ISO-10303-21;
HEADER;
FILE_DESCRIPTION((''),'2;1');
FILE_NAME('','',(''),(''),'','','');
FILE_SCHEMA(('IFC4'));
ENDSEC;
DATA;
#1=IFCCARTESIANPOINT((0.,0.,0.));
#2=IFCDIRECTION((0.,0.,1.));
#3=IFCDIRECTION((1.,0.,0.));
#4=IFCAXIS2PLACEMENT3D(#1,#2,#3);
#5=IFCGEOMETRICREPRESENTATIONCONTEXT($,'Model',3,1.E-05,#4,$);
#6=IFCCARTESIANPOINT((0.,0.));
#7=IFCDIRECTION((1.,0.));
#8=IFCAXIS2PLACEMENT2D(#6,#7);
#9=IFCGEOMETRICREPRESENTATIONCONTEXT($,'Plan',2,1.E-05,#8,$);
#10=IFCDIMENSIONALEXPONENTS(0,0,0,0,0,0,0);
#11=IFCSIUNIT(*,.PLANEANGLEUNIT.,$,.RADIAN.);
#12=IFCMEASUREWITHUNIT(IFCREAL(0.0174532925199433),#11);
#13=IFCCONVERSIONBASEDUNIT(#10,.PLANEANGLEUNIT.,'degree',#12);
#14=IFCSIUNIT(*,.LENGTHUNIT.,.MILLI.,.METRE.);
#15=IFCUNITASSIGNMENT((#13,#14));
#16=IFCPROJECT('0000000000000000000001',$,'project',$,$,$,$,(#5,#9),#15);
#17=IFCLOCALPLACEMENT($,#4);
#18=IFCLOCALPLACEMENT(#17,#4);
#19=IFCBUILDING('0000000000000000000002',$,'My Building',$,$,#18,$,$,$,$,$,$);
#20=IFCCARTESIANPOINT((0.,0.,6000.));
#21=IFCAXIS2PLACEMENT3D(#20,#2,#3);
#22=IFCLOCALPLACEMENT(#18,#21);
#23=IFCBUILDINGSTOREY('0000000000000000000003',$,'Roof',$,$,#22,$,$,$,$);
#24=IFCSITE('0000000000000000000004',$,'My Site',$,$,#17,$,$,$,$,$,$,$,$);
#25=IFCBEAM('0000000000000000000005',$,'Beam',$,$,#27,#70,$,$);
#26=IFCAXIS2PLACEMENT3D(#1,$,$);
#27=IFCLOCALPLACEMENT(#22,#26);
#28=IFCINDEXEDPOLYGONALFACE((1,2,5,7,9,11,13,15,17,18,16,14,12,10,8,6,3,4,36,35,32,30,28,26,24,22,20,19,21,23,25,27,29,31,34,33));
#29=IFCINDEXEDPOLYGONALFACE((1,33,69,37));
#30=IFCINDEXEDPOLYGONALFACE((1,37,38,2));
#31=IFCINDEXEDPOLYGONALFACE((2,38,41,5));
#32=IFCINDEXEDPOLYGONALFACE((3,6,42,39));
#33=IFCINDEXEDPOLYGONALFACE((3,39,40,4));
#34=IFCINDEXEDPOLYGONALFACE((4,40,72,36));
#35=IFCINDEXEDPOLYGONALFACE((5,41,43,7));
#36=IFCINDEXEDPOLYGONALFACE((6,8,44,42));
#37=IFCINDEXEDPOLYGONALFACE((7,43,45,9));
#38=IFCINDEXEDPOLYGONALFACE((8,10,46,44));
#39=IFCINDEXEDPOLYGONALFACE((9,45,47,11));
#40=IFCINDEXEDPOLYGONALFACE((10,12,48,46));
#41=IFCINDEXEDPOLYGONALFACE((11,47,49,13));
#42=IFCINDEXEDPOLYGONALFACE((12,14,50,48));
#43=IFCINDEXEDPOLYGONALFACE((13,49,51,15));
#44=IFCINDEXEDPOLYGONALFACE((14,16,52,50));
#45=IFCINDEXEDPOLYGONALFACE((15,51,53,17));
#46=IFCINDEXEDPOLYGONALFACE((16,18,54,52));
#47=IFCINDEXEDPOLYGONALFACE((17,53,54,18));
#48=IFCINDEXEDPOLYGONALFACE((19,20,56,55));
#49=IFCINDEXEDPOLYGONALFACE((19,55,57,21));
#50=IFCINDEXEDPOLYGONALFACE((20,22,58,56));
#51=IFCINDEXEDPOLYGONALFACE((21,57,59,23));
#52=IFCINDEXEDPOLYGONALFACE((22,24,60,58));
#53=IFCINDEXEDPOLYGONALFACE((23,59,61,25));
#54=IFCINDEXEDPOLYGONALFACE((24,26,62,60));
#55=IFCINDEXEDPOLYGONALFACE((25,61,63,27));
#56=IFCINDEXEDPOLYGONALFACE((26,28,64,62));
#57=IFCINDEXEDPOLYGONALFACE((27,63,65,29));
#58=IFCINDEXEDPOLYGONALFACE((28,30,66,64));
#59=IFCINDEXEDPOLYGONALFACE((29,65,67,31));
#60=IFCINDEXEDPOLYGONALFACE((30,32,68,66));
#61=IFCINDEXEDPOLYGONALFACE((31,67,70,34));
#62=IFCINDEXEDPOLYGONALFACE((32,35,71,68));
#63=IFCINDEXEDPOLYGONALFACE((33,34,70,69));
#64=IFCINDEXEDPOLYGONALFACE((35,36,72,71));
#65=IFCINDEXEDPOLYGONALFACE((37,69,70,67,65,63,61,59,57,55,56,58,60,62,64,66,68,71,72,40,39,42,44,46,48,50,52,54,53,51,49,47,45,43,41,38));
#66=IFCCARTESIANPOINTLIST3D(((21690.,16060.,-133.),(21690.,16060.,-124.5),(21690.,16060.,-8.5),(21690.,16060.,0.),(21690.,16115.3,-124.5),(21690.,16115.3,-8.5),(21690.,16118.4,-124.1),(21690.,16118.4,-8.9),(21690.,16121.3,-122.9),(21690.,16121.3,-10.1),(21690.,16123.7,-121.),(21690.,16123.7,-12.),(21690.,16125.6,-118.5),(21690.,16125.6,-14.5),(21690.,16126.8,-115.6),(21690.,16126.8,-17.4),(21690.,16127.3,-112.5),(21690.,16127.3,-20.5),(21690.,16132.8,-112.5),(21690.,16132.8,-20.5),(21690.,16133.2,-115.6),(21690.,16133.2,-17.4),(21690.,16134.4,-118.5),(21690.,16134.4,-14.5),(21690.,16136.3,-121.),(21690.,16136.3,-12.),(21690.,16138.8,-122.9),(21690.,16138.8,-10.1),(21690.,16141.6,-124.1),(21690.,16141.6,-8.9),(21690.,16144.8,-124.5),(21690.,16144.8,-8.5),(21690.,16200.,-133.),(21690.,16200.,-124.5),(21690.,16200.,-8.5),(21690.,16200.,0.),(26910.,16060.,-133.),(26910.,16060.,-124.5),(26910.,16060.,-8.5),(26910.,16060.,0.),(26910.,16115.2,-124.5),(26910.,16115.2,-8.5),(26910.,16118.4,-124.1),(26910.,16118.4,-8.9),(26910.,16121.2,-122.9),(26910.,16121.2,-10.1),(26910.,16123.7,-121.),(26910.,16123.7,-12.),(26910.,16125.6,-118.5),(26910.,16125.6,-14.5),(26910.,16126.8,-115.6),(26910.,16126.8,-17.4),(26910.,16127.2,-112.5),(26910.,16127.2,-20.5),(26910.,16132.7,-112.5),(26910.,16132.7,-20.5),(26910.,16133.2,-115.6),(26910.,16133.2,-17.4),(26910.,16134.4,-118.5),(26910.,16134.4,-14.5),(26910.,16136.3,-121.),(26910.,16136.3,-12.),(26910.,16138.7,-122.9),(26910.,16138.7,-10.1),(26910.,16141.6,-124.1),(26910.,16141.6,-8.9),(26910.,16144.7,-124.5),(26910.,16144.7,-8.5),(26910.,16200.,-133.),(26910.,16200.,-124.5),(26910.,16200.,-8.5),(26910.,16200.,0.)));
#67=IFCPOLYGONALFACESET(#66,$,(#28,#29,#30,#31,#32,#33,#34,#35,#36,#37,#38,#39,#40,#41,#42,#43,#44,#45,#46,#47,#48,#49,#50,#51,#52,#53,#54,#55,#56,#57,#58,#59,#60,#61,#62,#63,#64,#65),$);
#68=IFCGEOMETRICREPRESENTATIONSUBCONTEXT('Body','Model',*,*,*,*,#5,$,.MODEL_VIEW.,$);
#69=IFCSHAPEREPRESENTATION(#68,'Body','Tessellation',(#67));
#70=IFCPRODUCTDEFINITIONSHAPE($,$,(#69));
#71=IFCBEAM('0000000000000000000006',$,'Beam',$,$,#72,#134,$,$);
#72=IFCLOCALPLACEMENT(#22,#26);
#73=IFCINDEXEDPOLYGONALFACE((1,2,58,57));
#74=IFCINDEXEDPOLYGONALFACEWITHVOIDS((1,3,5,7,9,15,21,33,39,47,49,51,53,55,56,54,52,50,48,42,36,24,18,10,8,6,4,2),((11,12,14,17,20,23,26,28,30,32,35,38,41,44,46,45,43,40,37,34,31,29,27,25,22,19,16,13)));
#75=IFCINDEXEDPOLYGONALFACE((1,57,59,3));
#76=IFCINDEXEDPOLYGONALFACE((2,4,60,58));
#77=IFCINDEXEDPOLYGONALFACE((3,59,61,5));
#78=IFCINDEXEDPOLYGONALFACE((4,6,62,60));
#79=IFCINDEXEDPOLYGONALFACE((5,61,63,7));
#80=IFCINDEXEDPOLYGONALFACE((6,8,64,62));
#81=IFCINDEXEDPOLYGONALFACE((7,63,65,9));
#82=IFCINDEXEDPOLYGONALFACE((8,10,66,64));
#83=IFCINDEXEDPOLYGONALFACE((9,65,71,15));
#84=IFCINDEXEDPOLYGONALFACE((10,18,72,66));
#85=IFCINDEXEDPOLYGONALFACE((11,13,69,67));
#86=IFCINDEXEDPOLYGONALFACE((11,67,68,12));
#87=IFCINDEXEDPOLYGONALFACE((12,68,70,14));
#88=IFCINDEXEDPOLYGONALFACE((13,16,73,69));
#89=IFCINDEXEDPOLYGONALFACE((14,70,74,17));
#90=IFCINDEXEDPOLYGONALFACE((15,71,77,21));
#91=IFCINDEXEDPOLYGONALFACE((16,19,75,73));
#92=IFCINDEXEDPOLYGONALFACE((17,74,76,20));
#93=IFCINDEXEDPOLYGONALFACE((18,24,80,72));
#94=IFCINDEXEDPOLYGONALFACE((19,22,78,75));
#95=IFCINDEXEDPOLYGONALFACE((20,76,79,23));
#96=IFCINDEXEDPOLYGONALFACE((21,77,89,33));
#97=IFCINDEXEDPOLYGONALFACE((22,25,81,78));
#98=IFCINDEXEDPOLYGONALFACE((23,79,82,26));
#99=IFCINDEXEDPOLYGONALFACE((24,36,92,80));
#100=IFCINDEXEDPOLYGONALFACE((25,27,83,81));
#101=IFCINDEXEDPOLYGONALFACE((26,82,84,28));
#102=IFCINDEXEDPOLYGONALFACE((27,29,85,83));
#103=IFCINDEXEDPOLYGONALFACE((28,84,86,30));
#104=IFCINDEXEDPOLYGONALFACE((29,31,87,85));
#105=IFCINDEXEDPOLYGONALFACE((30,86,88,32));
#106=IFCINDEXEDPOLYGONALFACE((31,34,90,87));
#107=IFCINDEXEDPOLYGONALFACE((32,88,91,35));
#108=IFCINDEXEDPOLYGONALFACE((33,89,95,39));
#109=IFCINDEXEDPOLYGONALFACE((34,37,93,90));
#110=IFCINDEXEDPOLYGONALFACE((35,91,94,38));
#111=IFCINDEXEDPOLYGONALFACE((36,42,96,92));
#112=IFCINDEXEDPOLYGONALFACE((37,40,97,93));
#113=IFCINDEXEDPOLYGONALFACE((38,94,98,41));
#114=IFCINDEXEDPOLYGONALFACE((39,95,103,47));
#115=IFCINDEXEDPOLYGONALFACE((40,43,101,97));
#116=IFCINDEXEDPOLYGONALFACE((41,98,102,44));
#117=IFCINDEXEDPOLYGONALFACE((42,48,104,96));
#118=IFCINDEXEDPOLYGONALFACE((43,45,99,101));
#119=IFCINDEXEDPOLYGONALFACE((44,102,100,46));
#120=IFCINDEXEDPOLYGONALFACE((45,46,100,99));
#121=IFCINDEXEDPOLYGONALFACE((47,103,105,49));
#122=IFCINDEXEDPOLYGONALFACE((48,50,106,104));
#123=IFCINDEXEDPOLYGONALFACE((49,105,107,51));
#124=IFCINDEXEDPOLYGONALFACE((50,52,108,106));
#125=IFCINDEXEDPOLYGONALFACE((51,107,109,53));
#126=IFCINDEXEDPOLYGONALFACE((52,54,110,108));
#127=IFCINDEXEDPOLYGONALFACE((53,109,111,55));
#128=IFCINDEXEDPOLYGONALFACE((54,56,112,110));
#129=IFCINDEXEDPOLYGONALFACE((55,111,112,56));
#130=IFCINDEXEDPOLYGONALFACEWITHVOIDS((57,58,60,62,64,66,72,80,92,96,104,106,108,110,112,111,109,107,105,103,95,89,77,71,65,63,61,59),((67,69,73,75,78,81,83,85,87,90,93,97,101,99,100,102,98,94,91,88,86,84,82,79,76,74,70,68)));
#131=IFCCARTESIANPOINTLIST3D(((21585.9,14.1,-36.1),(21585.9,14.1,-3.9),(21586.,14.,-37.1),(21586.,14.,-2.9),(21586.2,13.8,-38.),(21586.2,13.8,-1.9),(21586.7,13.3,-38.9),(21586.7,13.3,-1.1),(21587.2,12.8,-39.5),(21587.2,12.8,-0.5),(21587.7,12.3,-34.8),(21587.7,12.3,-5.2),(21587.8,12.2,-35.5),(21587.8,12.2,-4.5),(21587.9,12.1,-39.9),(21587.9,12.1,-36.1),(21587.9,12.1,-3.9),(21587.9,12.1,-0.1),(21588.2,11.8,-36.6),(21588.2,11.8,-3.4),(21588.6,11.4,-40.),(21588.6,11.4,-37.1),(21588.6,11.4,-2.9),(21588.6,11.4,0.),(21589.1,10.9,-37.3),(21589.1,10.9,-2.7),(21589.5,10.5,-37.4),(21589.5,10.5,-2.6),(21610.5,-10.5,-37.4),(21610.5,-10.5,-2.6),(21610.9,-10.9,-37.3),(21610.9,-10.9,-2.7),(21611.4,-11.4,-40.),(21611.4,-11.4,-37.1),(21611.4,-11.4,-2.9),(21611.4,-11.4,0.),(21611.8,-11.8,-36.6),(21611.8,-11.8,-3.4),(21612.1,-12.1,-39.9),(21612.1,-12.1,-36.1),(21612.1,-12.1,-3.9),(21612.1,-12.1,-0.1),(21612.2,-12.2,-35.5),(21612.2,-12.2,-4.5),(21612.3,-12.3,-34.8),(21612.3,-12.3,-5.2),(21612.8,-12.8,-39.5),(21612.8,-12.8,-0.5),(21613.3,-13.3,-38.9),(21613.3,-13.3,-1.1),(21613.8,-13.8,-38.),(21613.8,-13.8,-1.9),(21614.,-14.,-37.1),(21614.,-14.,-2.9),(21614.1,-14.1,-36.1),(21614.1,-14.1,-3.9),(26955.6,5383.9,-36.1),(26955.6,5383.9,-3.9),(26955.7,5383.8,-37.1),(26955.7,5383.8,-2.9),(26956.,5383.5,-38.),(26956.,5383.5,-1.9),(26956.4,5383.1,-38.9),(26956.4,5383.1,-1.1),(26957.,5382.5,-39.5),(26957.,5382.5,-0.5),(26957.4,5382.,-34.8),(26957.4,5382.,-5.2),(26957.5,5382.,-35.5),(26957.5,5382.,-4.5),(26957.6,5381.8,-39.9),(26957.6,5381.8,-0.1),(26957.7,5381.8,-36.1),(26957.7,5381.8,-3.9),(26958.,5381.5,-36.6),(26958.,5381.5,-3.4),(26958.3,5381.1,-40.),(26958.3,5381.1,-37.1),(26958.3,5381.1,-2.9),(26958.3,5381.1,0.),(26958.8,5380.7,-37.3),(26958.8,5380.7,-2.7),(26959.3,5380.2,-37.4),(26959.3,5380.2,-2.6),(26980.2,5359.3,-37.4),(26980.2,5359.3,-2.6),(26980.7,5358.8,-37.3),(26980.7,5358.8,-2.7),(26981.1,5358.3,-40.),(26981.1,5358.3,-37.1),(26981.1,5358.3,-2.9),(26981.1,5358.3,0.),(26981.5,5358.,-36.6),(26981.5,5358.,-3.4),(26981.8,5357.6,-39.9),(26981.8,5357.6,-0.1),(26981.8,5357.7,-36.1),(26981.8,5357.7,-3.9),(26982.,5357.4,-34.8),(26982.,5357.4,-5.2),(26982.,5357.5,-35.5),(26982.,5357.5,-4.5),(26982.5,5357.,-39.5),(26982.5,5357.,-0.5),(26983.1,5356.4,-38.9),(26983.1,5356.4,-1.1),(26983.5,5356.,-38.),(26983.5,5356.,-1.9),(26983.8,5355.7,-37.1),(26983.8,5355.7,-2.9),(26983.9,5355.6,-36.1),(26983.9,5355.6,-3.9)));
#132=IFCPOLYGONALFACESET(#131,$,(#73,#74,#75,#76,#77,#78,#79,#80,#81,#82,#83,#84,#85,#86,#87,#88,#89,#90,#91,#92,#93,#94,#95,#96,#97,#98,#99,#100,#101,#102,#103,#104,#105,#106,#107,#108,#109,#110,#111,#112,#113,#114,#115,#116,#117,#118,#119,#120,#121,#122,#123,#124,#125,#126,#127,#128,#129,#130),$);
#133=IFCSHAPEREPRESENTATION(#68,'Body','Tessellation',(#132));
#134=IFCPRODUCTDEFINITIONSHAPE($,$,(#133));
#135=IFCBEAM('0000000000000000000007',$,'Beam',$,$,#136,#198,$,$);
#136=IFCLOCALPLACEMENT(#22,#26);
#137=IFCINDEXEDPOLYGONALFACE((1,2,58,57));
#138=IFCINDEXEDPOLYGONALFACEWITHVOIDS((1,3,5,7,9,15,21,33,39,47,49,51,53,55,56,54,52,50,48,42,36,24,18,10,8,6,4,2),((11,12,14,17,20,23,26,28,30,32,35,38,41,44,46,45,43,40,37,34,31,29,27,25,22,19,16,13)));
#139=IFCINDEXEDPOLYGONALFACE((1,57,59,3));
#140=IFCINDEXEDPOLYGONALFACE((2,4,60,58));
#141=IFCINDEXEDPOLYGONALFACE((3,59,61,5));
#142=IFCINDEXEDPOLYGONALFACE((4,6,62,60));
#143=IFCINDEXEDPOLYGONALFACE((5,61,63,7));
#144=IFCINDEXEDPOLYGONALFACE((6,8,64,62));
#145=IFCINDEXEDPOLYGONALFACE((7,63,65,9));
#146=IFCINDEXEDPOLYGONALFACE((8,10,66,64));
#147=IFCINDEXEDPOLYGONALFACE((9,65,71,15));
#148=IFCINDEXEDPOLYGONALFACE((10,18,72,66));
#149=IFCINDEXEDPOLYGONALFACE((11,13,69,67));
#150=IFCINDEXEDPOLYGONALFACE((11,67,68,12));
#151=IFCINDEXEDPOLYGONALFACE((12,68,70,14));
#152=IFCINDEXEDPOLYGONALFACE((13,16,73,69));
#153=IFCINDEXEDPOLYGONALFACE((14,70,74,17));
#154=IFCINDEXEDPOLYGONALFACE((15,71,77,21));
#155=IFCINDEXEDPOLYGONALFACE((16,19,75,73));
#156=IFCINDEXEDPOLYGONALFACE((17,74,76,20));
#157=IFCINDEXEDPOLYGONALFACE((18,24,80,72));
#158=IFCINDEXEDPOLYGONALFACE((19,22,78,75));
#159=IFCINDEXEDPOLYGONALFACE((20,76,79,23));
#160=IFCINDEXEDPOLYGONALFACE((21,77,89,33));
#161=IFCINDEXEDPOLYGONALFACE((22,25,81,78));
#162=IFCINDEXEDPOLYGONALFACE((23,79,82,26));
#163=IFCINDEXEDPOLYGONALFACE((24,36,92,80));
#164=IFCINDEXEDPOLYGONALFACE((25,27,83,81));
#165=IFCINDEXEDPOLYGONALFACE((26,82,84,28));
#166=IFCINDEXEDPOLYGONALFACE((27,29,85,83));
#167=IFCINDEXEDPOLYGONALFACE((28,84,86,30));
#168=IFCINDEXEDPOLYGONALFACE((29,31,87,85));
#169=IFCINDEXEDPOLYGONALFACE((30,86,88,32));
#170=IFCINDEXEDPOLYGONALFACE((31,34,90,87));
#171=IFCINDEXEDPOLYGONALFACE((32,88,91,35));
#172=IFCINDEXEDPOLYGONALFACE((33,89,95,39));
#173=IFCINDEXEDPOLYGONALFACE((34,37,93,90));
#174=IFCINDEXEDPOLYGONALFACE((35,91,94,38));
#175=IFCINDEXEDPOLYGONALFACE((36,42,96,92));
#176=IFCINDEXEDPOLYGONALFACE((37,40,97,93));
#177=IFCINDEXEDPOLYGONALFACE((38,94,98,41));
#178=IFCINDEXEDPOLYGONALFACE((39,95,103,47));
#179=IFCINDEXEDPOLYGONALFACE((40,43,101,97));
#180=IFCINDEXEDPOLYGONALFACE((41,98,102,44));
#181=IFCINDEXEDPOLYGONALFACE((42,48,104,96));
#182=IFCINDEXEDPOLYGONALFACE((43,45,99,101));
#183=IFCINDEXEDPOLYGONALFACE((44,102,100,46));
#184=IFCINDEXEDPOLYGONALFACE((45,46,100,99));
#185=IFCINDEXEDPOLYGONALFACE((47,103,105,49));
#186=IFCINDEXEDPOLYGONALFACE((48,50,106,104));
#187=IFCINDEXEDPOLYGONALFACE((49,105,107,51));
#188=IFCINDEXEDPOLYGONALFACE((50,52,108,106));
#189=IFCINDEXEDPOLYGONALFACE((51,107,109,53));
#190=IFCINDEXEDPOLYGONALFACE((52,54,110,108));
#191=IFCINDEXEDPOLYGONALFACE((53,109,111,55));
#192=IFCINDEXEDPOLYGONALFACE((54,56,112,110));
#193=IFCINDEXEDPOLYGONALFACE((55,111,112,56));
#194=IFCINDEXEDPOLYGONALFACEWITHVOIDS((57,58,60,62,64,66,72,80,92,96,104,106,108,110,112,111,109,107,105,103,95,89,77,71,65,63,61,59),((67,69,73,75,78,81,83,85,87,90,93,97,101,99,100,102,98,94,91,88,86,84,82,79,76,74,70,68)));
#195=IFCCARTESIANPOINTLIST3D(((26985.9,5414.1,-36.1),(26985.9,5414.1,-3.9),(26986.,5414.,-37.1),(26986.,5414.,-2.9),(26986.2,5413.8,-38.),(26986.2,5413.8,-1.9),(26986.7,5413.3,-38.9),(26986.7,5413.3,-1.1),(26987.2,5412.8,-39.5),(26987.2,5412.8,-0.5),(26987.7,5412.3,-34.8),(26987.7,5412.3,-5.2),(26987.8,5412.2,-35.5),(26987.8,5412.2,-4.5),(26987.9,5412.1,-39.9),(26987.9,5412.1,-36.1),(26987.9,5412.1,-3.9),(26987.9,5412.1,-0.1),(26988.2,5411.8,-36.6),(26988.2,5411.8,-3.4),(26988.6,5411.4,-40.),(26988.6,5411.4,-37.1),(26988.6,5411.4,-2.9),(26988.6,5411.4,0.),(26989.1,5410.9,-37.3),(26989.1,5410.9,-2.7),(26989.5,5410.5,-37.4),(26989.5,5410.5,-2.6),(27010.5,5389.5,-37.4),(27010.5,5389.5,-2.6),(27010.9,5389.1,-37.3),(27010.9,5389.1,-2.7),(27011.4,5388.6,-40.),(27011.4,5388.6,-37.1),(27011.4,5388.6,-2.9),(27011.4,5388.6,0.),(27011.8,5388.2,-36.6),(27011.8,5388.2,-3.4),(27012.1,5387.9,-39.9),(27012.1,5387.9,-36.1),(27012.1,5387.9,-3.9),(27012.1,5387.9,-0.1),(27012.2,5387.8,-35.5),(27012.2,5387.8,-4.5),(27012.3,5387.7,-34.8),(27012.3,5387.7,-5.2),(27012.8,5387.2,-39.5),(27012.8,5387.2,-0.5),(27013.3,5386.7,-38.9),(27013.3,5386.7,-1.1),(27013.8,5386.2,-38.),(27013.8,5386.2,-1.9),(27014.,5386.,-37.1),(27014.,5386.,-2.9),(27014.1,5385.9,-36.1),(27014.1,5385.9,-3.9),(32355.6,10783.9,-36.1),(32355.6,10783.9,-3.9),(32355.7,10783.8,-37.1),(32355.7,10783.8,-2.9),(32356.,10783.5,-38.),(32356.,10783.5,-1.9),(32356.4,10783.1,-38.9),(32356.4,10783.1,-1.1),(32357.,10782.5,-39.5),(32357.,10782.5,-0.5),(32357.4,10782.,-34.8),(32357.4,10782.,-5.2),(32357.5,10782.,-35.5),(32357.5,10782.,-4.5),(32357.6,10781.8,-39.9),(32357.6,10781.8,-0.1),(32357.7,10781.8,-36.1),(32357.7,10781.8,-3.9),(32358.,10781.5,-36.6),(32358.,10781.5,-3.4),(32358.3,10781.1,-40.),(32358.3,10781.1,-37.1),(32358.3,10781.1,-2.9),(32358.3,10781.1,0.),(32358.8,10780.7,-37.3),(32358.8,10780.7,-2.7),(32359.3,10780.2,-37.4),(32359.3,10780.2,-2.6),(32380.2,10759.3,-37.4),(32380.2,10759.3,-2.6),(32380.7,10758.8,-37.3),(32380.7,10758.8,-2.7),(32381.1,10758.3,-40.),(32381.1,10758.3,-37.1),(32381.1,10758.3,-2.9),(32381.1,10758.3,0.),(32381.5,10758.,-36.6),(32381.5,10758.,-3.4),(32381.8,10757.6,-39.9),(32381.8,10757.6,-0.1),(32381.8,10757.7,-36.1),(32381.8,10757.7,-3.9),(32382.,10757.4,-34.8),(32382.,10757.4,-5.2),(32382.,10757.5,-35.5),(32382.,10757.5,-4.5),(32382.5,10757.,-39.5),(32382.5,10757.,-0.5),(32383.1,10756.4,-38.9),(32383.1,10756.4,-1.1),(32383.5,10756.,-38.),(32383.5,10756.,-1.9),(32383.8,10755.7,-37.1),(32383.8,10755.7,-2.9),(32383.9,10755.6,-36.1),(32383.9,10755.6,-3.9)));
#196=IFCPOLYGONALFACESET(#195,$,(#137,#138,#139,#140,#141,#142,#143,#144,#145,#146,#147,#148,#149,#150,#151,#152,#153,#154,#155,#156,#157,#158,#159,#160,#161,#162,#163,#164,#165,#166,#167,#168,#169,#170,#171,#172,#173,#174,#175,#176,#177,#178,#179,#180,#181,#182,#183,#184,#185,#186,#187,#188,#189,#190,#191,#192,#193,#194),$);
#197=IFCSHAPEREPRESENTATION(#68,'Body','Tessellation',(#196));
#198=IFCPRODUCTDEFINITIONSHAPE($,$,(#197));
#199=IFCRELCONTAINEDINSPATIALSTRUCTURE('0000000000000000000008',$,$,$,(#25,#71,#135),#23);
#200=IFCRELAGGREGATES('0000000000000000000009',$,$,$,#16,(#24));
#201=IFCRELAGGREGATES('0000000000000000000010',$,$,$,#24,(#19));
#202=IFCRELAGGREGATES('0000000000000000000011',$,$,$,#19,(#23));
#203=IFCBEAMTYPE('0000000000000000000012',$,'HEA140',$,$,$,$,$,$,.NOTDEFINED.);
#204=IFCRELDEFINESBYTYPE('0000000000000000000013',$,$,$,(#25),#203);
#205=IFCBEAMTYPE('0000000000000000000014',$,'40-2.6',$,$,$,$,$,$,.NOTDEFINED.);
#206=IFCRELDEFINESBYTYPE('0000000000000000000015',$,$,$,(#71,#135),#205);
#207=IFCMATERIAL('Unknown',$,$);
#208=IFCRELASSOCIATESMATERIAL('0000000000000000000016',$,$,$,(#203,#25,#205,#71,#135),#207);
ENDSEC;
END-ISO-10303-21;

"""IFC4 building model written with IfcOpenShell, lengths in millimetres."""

from ifc_helpers import new_model, entity, si_unit, converted_unit, frame, origin_with_axes, origin_2d_with_axis, place, context, subcontext, project, spatial, hollow_rectangle, i_section, extrude, material, material_profile, profile_set, profile_usage, type_object, element, save


model = new_model("IFC4")

# Units and contexts
model_context = context("Model", 3, precision=1e-05, world=origin_with_axes())
plan_context = context("Plan", 2, precision=1e-05, world=origin_2d_with_axis())
body_context = subcontext(model_context, "Body", "Model", "MODEL_VIEW")
ifc_project = project(units=[converted_unit("PLANEANGLEUNIT", "degree", entity("IfcReal", 0.0174532925199433), si_unit("PLANEANGLEUNIT", "RADIAN"), dimensions=[0, 0, 0, 0, 0, 0, 0]), si_unit("LENGTHUNIT", "METRE", prefix="MILLI")], contexts=[model_context, plan_context])

# Site, building, storey
site_placement = place(None, origin_with_axes())
site = spatial("IfcSite", under=ifc_project, at=site_placement, Name="My Site")
building_placement = place(site_placement, origin_with_axes())
building = spatial("IfcBuilding", under=site, at=building_placement, Name="My Building")
storey_placement = place(building_placement, frame((0.0, 0.0, 6000.0), z_axis=(0.0, 0.0, 1.0), x_axis=(1.0, 0.0, 0.0)))
storey = spatial("IfcBuildingStorey", under=building, at=storey_placement, Name="Roof")

# Beams
ifc_material = material(Name="Unknown")
ifc_material_profile_1 = material_profile(ifc_material, i_section(OverallWidth=140.0, OverallDepth=133.0, WebThickness=5.5, FlangeThickness=8.5, FilletRadius=12.0))
ifc_profile_set_1 = profile_set([ifc_material_profile_1])
beam_type_1 = type_object("IfcBeamType", Name="HEA140", PredefinedType="NOTDEFINED", material=ifc_profile_set_1)
ifc_profile_usage_1 = profile_usage(ifc_profile_set_1, cardinal=7)
beam_1_placement = place(storey_placement, frame((21690.0, 16200.0, 0.0), z_axis=(1.0, 0.0, 0.0), x_axis=(0.0, 1.0, 0.0)))
element("IfcBeam", 1, at=beam_1_placement, inside=storey, type_object=beam_type_1, material=ifc_profile_usage_1, Name="Beam", context=body_context, shape_type="SweptSolid", body=[
    extrude(i_section(OverallWidth=140.0, OverallDepth=133.0, WebThickness=5.5, FlangeThickness=8.5, FilletRadius=12.0), frame((-70.0, -66.5, 0.0), z_axis=(0.0, 0.0, 1.0), x_axis=(1.0, 0.0, 0.0)), (0.0, 0.0, 1.0), 5220.0),
])
ifc_material_profile_2 = material_profile(ifc_material, hollow_rectangle(XDim=40.0, YDim=40.0, WallThickness=2.6, InnerFilletRadius=2.6, OuterFilletRadius=3.9))
ifc_profile_set_2 = profile_set([ifc_material_profile_2])
ifc_profile_usage_2 = profile_usage(ifc_profile_set_2, cardinal=8)
beam_type_2 = type_object("IfcBeamType", Name="40-2.6", PredefinedType="NOTDEFINED", material=ifc_profile_set_2)
beam_2_placement = place(storey_placement, frame((21600.0, 0.0, 0.0), z_axis=(0.707107, 0.707107, 0.0), x_axis=(-0.707107, 0.707107, 0.0)))
element("IfcBeam", 2, at=beam_2_placement, inside=storey, type_object=beam_type_2, material=ifc_profile_usage_2, Name="Beam", context=body_context, shape_type="SweptSolid", body=[
    extrude(hollow_rectangle(XDim=40.0, YDim=40.0, WallThickness=2.6, InnerFilletRadius=2.6, OuterFilletRadius=3.9), frame((0.0, -20.0, 0.0), z_axis=(0.0, 0.0, 1.0), x_axis=(1.0, 0.0, 0.0)), (0.0, 0.0, 1.0), 7594.0),
])
ifc_profile_usage_3 = profile_usage(ifc_profile_set_2, cardinal=8)
beam_3_placement = place(storey_placement, frame((27000.0, 5400.0, 0.0), z_axis=(0.707107, 0.707107, 0.0), x_axis=(-0.707107, 0.707107, 0.0)))
element("IfcBeam", 3, at=beam_3_placement, inside=storey, type_object=beam_type_2, material=ifc_profile_usage_3, Name="Beam", context=body_context, shape_type="SweptSolid", body=[
    extrude(hollow_rectangle(XDim=40.0, YDim=40.0, WallThickness=2.6, InnerFilletRadius=2.6, OuterFilletRadius=3.9), frame((0.0, -20.0, 0.0), z_axis=(0.0, 0.0, 1.0), x_axis=(1.0, 0.0, 0.0)), (0.0, 0.0, 1.0), 7594.0),
])

save(model, "model.ifc")
